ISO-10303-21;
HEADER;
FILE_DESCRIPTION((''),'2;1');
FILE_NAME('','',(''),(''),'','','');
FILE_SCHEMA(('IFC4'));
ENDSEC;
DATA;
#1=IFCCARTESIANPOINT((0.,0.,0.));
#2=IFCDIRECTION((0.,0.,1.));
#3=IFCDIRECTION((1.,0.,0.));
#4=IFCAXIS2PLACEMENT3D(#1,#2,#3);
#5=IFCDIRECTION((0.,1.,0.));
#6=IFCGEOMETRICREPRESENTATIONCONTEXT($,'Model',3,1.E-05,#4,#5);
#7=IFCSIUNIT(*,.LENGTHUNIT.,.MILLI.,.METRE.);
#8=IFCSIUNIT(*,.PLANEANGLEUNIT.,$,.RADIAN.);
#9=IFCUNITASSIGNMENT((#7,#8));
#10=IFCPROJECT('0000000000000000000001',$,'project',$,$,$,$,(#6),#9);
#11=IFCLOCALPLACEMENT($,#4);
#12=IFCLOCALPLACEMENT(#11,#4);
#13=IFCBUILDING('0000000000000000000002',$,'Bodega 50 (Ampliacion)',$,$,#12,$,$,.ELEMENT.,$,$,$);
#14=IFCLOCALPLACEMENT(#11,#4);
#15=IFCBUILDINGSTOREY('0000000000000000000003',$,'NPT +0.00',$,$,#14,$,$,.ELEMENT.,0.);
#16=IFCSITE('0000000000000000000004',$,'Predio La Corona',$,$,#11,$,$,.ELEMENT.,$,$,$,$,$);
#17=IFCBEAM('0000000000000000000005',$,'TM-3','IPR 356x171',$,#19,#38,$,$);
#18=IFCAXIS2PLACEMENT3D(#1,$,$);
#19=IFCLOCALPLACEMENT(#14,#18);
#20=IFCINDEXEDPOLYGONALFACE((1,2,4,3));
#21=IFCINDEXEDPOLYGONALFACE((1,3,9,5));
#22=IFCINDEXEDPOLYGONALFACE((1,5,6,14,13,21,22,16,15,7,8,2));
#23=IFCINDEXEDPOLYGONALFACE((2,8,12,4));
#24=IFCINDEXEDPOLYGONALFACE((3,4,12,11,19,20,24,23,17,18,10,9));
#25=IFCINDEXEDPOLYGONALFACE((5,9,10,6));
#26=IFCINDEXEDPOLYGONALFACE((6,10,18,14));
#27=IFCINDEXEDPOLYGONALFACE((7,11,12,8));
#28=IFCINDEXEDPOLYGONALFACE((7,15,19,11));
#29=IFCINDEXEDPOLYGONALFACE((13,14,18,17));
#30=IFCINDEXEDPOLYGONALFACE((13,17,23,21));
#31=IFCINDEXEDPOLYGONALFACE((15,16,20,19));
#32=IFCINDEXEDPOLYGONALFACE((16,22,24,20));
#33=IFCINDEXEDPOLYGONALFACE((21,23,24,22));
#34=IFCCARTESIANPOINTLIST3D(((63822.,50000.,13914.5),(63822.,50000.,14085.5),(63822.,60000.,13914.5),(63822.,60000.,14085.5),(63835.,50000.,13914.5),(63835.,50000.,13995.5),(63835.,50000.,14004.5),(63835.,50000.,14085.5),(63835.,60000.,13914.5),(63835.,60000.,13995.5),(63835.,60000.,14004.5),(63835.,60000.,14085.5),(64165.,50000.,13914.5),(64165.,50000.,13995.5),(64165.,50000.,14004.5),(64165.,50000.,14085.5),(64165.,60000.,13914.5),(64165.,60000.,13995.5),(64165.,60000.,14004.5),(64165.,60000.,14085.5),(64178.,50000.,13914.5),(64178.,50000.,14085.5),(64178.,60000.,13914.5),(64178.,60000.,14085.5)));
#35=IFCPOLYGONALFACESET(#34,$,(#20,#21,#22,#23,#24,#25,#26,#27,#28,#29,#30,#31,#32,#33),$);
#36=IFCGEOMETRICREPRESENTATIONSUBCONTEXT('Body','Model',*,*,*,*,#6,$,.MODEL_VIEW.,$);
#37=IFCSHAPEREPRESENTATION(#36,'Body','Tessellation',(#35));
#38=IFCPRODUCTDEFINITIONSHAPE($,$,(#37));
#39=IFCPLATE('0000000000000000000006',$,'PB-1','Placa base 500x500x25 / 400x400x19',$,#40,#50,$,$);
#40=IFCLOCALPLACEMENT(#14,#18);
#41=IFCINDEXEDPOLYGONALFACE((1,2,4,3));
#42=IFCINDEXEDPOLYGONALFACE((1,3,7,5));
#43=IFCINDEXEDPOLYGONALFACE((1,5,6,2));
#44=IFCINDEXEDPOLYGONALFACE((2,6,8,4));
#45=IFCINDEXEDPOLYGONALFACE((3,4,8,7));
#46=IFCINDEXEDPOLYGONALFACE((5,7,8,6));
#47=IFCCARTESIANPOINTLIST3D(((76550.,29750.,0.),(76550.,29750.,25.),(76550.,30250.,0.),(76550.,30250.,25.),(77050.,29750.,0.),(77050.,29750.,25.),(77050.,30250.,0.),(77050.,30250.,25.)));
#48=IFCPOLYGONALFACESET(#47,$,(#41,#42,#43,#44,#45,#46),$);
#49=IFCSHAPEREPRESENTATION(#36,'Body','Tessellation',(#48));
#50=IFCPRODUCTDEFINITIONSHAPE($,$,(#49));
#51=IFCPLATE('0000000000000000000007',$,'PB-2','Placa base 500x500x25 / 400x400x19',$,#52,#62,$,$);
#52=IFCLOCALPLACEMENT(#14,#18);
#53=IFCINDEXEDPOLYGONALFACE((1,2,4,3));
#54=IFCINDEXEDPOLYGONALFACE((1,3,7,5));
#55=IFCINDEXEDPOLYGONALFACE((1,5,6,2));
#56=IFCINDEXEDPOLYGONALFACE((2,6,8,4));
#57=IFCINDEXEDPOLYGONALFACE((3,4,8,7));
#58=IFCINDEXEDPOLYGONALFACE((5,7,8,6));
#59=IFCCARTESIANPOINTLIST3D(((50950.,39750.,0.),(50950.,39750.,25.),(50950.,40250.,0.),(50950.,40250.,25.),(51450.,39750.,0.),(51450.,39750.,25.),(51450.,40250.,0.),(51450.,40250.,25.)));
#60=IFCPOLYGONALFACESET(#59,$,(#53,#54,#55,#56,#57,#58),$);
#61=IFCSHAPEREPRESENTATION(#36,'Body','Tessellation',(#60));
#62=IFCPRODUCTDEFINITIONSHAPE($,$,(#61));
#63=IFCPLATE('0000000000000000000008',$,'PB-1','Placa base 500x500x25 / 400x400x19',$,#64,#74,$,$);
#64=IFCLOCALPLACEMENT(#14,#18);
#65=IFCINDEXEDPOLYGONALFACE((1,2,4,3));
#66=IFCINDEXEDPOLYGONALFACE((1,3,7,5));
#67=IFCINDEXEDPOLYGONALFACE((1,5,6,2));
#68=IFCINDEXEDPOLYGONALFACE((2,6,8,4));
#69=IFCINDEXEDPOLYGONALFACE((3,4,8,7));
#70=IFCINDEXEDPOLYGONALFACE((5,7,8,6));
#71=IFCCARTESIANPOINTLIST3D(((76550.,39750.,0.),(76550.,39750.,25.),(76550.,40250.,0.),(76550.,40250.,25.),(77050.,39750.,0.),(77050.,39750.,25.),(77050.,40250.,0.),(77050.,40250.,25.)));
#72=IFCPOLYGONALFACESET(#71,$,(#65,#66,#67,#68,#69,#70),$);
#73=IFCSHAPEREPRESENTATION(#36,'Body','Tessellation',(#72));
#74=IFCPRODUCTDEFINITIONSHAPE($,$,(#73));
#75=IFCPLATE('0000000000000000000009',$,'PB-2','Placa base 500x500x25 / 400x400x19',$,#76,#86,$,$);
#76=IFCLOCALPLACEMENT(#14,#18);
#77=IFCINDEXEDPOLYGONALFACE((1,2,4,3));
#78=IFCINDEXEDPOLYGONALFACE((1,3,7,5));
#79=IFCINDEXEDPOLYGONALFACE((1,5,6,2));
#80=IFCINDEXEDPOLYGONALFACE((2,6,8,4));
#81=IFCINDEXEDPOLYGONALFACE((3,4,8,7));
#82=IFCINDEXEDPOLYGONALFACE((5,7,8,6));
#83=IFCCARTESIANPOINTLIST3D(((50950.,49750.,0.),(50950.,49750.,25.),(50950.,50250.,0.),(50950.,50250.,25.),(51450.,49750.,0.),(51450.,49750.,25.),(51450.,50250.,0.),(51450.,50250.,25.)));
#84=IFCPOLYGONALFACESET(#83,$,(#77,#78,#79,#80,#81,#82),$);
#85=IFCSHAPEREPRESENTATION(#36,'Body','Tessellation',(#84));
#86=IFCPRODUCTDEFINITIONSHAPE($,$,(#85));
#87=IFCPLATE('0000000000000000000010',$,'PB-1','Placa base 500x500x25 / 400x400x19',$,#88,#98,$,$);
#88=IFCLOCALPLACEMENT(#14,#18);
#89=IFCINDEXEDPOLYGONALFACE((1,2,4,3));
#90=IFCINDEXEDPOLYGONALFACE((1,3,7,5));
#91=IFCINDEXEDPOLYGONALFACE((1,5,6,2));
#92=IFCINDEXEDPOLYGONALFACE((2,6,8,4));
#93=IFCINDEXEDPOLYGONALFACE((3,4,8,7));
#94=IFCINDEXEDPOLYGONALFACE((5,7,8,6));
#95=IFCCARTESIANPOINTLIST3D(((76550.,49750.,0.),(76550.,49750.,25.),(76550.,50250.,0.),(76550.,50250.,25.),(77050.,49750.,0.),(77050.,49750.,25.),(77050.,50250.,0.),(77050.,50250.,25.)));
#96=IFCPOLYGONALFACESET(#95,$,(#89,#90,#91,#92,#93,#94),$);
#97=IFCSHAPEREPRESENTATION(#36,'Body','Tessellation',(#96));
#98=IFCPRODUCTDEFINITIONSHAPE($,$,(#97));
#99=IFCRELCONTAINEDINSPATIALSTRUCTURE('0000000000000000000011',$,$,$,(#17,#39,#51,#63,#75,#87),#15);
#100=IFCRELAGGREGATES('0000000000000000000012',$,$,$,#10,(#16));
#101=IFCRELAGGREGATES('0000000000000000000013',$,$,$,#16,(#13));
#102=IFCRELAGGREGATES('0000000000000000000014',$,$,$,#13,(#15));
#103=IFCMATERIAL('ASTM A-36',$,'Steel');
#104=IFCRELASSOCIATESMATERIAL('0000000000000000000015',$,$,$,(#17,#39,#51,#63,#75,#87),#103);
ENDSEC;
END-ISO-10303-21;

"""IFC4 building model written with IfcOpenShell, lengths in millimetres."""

from ifc_helpers import new_model, si_unit, direction, frame, origin_with_axes, origin_2d, place, context, subcontext, project, spatial, rectangle, i_section, extrude, material, element, save


model = new_model("IFC4")

# Units and contexts
model_context = context("Model", 3, precision=1e-05, world=origin_with_axes(), true_north=direction((0.0, 1.0, 0.0)))
body_context = subcontext(model_context, "Body", "Model", "MODEL_VIEW")
ifc_project = project(units=[si_unit("LENGTHUNIT", "METRE", prefix="MILLI"), si_unit("PLANEANGLEUNIT", "RADIAN")], contexts=[model_context])

# Site, building, storey
site_placement = place(None, origin_with_axes())
site = spatial("IfcSite", under=ifc_project, at=site_placement, Name="Predio La Corona", CompositionType="ELEMENT")
building_placement = place(site_placement, origin_with_axes())
building = spatial("IfcBuilding", under=site, at=building_placement, Name="Bodega 50 (Ampliacion)", CompositionType="ELEMENT")
storey_placement = place(site_placement, origin_with_axes())
storey = spatial("IfcBuildingStorey", under=building, at=storey_placement, Name="NPT +0.00", CompositionType="ELEMENT", Elevation=0.0)

# Shared definitions
ifc_material = material(Name="ASTM A-36", Category="Steel")

# Beam
for number, where, z_axis, x_axis, name in (
    (1, (64000.0, 50000.0, 14000.0), (0.0, 1.0, 0.0), (0.0, 0.0, 1.0), "TM-3"),
):
    element("IfcBeam", number, at=place(storey_placement, frame(where, z_axis=z_axis, x_axis=x_axis)), inside=storey, material=ifc_material, Name=name, Description="IPR 356x171", context=body_context, shape_type="SweptSolid", body=[
        extrude(i_section(OverallWidth=171.0, OverallDepth=356.0, WebThickness=9.0, FlangeThickness=13.0, at=origin_2d()), origin_with_axes(), (0.0, 0.0, 1.0), 10000.0),
    ])

# Plates
for number, where, z_axis, x_axis, name in (
    (2, (76800.0, 30000.0, 0.0), (0.0, 0.0, 1.0), (1.0, 0.0, 0.0), "PB-1"),
    (3, (51200.0, 40000.0, 0.0), (0.0, 0.0, 1.0), (1.0, 0.0, 0.0), "PB-2"),
    (4, (76800.0, 40000.0, 0.0), (0.0, 0.0, 1.0), (1.0, 0.0, 0.0), "PB-1"),
    (5, (51200.0, 50000.0, 0.0), (0.0, 0.0, 1.0), (1.0, 0.0, 0.0), "PB-2"),
    (6, (76800.0, 50000.0, 0.0), (0.0, 0.0, 1.0), (1.0, 0.0, 0.0), "PB-1"),
):
    element("IfcPlate", number, at=place(storey_placement, frame(where, z_axis=z_axis, x_axis=x_axis)), inside=storey, material=ifc_material, Name=name, Description="Placa base 500x500x25 / 400x400x19", context=body_context, shape_type="SweptSolid", body=[
        extrude(rectangle(XDim=500.0, YDim=500.0, at=origin_2d()), origin_with_axes(), (0.0, 0.0, 1.0), 25.0),
    ])

save(model, "model.ifc")
